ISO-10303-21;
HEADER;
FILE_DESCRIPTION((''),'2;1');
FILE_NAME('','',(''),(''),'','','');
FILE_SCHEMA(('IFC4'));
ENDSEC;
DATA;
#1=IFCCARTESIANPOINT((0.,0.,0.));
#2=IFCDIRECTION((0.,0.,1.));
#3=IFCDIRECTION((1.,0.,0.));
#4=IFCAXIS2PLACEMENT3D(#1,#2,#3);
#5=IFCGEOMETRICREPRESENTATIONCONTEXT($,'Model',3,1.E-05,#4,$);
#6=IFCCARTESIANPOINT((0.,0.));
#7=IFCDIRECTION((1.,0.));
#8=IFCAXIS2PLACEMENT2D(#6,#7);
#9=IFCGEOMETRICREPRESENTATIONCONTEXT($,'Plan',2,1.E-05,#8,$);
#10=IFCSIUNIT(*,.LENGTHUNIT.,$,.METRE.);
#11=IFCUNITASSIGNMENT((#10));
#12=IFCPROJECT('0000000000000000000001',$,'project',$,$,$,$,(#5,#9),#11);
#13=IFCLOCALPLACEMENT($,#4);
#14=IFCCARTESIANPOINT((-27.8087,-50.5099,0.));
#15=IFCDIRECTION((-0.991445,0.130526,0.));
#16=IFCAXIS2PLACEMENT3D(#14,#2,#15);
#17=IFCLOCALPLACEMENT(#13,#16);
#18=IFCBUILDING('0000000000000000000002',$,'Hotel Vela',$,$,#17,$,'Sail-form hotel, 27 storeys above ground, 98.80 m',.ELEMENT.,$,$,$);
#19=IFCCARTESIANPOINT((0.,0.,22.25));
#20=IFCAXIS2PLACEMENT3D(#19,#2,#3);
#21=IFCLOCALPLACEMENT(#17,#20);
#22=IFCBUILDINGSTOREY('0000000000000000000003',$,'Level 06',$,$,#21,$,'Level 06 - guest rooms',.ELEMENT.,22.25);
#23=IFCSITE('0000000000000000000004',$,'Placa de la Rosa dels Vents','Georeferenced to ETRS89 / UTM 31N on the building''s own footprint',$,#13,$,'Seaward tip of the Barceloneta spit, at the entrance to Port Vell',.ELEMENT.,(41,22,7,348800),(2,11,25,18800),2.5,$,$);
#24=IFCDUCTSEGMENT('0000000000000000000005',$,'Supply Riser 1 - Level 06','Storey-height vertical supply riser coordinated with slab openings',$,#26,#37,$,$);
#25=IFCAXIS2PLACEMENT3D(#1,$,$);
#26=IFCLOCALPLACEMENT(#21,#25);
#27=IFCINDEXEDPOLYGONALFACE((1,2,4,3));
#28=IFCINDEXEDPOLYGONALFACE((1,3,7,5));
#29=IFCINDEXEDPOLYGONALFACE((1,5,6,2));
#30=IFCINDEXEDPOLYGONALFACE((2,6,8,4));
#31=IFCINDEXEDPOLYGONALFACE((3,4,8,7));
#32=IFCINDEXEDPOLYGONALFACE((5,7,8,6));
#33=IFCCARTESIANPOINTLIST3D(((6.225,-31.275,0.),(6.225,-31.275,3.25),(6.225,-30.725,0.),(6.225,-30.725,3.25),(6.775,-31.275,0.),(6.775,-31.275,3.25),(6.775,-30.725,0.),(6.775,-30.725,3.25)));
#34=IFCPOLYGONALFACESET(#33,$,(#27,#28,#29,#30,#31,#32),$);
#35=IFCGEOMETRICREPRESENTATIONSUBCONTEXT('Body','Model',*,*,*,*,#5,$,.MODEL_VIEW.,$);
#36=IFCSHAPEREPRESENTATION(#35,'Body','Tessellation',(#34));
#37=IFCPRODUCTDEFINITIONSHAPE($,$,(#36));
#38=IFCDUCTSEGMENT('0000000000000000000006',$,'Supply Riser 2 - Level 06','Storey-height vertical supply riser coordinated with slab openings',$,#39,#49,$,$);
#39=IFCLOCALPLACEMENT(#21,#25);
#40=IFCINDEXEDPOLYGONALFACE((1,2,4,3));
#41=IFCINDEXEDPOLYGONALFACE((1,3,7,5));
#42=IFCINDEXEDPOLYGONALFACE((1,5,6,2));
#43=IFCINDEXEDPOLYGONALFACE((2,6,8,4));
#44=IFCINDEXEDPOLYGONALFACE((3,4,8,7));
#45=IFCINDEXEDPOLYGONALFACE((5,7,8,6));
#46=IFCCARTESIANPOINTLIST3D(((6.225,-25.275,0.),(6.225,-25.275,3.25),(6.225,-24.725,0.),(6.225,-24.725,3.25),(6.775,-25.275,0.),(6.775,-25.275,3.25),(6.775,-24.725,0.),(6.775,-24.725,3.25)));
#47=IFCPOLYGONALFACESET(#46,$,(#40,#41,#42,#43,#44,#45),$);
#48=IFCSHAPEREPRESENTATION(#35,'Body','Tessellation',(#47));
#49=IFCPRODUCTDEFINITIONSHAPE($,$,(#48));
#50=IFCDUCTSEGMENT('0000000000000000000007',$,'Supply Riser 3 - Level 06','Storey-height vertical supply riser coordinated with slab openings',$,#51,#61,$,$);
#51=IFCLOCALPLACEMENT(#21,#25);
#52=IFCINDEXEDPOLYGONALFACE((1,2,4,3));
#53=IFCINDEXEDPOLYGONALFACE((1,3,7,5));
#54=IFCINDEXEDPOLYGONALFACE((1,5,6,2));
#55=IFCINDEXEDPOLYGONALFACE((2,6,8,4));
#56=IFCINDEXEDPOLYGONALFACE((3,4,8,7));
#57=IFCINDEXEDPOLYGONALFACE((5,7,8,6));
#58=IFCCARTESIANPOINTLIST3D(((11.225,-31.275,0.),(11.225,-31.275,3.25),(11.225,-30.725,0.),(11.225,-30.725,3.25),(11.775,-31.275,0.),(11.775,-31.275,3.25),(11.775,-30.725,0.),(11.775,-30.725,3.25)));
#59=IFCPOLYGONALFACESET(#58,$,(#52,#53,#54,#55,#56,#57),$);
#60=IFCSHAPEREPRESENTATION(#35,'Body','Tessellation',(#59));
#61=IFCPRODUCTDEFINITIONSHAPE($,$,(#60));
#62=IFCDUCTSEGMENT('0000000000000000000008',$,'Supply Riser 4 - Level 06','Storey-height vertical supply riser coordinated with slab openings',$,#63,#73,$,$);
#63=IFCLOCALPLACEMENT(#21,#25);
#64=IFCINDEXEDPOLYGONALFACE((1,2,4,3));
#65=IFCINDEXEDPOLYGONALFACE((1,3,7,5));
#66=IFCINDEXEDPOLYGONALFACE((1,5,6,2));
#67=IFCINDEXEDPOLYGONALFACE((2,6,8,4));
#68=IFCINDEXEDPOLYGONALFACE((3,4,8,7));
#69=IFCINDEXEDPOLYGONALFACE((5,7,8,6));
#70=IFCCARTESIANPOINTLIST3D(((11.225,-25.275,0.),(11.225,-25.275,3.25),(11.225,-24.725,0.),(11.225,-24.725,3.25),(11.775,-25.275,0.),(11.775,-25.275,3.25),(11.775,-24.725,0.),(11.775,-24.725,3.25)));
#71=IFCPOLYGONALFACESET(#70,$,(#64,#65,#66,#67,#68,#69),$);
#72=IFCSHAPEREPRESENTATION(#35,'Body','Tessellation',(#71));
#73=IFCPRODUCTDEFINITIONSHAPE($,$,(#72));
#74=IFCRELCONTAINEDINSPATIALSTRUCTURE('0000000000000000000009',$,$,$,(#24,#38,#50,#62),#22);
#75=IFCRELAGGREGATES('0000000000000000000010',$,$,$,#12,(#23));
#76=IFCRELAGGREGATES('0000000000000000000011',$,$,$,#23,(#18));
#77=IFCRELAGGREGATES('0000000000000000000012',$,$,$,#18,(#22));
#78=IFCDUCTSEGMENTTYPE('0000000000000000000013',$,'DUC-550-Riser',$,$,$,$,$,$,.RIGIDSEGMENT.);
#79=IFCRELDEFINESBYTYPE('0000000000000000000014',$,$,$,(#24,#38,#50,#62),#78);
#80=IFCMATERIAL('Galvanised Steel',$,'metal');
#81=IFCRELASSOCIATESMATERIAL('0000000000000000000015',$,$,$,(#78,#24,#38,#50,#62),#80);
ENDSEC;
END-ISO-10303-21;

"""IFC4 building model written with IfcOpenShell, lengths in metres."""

from ifc_helpers import new_model, si_unit, frame, origin_with_axes, origin_2d_with_axis, place, context, subcontext, project, spatial, line, indexed_curve, outline, extrude, material, type_object, element, save


model = new_model("IFC4")

# Units and contexts
model_context = context("Model", 3, precision=1e-05, world=origin_with_axes())
plan_context = context("Plan", 2, precision=1e-05, world=origin_2d_with_axis())
body_context = subcontext(model_context, "Body", "Model", "MODEL_VIEW")
ifc_project = project(units=[si_unit("LENGTHUNIT", "METRE")], contexts=[model_context, plan_context])

# Site, building, storey
site_placement = place(None, origin_with_axes())
site = spatial("IfcSite", under=ifc_project, at=site_placement, Name="Placa de la Rosa dels Vents", Description="Georeferenced to ETRS89 / UTM 31N on the building's own footprint", LongName="Seaward tip of the Barceloneta spit, at the entrance to Port Vell", CompositionType="ELEMENT", RefLatitude=(41, 22, 7, 348800), RefLongitude=(2, 11, 25, 18800), RefElevation=2.5)
building_placement = place(site_placement, frame((-27.8087, -50.5099, 0.0), z_axis=(0.0, 0.0, 1.0), x_axis=(-0.991445, 0.130526, 0.0)))
building = spatial("IfcBuilding", under=site, at=building_placement, Name="Hotel Vela", LongName="Sail-form hotel, 27 storeys above ground, 98.80 m", CompositionType="ELEMENT")
storey_placement = place(building_placement, frame((0.0, 0.0, 22.25), z_axis=(0.0, 0.0, 1.0), x_axis=(1.0, 0.0, 0.0)))
storey = spatial("IfcBuildingStorey", under=building, at=storey_placement, Name="Level 06", LongName="Level 06 - guest rooms", CompositionType="ELEMENT", Elevation=22.25)

# Duct segments
ifc_material = material(Name="Galvanised Steel", Category="metal")
duct_segment_type = type_object("IfcDuctSegmentType", Name="DUC-550-Riser", PredefinedType="RIGIDSEGMENT", material=ifc_material)
for number, where, z_axis, x_axis, name in (
    (1, (6.225, -31.275, 0.0), (0.0, 0.0, 1.0), (1.0, 0.0, 0.0), "Supply Riser 1 - Level 06"),
    (2, (6.225, -25.275, 0.0), (0.0, 0.0, 1.0), (1.0, 0.0, 0.0), "Supply Riser 2 - Level 06"),
    (3, (11.225, -31.275, 0.0), (0.0, 0.0, 1.0), (1.0, 0.0, 0.0), "Supply Riser 3 - Level 06"),
    (4, (11.225, -25.275, 0.0), (0.0, 0.0, 1.0), (1.0, 0.0, 0.0), "Supply Riser 4 - Level 06"),
):
    element("IfcDuctSegment", number, at=place(storey_placement, frame(where, z_axis=z_axis, x_axis=x_axis)), inside=storey, type_object=duct_segment_type, material=ifc_material, Name=name, Description="Storey-height vertical supply riser coordinated with slab openings", context=body_context, shape_type="SweptSolid", body=[
        extrude(outline(indexed_curve([(0.0, 0.0), (0.55, 0.0), (0.55, 0.55), (0.0, 0.55)], segments=[line(1, 2, 3, 4, 1)])), origin_with_axes(), (0.0, 0.0, 1.0), 3.25),
    ])

save(model, "model.ifc")
